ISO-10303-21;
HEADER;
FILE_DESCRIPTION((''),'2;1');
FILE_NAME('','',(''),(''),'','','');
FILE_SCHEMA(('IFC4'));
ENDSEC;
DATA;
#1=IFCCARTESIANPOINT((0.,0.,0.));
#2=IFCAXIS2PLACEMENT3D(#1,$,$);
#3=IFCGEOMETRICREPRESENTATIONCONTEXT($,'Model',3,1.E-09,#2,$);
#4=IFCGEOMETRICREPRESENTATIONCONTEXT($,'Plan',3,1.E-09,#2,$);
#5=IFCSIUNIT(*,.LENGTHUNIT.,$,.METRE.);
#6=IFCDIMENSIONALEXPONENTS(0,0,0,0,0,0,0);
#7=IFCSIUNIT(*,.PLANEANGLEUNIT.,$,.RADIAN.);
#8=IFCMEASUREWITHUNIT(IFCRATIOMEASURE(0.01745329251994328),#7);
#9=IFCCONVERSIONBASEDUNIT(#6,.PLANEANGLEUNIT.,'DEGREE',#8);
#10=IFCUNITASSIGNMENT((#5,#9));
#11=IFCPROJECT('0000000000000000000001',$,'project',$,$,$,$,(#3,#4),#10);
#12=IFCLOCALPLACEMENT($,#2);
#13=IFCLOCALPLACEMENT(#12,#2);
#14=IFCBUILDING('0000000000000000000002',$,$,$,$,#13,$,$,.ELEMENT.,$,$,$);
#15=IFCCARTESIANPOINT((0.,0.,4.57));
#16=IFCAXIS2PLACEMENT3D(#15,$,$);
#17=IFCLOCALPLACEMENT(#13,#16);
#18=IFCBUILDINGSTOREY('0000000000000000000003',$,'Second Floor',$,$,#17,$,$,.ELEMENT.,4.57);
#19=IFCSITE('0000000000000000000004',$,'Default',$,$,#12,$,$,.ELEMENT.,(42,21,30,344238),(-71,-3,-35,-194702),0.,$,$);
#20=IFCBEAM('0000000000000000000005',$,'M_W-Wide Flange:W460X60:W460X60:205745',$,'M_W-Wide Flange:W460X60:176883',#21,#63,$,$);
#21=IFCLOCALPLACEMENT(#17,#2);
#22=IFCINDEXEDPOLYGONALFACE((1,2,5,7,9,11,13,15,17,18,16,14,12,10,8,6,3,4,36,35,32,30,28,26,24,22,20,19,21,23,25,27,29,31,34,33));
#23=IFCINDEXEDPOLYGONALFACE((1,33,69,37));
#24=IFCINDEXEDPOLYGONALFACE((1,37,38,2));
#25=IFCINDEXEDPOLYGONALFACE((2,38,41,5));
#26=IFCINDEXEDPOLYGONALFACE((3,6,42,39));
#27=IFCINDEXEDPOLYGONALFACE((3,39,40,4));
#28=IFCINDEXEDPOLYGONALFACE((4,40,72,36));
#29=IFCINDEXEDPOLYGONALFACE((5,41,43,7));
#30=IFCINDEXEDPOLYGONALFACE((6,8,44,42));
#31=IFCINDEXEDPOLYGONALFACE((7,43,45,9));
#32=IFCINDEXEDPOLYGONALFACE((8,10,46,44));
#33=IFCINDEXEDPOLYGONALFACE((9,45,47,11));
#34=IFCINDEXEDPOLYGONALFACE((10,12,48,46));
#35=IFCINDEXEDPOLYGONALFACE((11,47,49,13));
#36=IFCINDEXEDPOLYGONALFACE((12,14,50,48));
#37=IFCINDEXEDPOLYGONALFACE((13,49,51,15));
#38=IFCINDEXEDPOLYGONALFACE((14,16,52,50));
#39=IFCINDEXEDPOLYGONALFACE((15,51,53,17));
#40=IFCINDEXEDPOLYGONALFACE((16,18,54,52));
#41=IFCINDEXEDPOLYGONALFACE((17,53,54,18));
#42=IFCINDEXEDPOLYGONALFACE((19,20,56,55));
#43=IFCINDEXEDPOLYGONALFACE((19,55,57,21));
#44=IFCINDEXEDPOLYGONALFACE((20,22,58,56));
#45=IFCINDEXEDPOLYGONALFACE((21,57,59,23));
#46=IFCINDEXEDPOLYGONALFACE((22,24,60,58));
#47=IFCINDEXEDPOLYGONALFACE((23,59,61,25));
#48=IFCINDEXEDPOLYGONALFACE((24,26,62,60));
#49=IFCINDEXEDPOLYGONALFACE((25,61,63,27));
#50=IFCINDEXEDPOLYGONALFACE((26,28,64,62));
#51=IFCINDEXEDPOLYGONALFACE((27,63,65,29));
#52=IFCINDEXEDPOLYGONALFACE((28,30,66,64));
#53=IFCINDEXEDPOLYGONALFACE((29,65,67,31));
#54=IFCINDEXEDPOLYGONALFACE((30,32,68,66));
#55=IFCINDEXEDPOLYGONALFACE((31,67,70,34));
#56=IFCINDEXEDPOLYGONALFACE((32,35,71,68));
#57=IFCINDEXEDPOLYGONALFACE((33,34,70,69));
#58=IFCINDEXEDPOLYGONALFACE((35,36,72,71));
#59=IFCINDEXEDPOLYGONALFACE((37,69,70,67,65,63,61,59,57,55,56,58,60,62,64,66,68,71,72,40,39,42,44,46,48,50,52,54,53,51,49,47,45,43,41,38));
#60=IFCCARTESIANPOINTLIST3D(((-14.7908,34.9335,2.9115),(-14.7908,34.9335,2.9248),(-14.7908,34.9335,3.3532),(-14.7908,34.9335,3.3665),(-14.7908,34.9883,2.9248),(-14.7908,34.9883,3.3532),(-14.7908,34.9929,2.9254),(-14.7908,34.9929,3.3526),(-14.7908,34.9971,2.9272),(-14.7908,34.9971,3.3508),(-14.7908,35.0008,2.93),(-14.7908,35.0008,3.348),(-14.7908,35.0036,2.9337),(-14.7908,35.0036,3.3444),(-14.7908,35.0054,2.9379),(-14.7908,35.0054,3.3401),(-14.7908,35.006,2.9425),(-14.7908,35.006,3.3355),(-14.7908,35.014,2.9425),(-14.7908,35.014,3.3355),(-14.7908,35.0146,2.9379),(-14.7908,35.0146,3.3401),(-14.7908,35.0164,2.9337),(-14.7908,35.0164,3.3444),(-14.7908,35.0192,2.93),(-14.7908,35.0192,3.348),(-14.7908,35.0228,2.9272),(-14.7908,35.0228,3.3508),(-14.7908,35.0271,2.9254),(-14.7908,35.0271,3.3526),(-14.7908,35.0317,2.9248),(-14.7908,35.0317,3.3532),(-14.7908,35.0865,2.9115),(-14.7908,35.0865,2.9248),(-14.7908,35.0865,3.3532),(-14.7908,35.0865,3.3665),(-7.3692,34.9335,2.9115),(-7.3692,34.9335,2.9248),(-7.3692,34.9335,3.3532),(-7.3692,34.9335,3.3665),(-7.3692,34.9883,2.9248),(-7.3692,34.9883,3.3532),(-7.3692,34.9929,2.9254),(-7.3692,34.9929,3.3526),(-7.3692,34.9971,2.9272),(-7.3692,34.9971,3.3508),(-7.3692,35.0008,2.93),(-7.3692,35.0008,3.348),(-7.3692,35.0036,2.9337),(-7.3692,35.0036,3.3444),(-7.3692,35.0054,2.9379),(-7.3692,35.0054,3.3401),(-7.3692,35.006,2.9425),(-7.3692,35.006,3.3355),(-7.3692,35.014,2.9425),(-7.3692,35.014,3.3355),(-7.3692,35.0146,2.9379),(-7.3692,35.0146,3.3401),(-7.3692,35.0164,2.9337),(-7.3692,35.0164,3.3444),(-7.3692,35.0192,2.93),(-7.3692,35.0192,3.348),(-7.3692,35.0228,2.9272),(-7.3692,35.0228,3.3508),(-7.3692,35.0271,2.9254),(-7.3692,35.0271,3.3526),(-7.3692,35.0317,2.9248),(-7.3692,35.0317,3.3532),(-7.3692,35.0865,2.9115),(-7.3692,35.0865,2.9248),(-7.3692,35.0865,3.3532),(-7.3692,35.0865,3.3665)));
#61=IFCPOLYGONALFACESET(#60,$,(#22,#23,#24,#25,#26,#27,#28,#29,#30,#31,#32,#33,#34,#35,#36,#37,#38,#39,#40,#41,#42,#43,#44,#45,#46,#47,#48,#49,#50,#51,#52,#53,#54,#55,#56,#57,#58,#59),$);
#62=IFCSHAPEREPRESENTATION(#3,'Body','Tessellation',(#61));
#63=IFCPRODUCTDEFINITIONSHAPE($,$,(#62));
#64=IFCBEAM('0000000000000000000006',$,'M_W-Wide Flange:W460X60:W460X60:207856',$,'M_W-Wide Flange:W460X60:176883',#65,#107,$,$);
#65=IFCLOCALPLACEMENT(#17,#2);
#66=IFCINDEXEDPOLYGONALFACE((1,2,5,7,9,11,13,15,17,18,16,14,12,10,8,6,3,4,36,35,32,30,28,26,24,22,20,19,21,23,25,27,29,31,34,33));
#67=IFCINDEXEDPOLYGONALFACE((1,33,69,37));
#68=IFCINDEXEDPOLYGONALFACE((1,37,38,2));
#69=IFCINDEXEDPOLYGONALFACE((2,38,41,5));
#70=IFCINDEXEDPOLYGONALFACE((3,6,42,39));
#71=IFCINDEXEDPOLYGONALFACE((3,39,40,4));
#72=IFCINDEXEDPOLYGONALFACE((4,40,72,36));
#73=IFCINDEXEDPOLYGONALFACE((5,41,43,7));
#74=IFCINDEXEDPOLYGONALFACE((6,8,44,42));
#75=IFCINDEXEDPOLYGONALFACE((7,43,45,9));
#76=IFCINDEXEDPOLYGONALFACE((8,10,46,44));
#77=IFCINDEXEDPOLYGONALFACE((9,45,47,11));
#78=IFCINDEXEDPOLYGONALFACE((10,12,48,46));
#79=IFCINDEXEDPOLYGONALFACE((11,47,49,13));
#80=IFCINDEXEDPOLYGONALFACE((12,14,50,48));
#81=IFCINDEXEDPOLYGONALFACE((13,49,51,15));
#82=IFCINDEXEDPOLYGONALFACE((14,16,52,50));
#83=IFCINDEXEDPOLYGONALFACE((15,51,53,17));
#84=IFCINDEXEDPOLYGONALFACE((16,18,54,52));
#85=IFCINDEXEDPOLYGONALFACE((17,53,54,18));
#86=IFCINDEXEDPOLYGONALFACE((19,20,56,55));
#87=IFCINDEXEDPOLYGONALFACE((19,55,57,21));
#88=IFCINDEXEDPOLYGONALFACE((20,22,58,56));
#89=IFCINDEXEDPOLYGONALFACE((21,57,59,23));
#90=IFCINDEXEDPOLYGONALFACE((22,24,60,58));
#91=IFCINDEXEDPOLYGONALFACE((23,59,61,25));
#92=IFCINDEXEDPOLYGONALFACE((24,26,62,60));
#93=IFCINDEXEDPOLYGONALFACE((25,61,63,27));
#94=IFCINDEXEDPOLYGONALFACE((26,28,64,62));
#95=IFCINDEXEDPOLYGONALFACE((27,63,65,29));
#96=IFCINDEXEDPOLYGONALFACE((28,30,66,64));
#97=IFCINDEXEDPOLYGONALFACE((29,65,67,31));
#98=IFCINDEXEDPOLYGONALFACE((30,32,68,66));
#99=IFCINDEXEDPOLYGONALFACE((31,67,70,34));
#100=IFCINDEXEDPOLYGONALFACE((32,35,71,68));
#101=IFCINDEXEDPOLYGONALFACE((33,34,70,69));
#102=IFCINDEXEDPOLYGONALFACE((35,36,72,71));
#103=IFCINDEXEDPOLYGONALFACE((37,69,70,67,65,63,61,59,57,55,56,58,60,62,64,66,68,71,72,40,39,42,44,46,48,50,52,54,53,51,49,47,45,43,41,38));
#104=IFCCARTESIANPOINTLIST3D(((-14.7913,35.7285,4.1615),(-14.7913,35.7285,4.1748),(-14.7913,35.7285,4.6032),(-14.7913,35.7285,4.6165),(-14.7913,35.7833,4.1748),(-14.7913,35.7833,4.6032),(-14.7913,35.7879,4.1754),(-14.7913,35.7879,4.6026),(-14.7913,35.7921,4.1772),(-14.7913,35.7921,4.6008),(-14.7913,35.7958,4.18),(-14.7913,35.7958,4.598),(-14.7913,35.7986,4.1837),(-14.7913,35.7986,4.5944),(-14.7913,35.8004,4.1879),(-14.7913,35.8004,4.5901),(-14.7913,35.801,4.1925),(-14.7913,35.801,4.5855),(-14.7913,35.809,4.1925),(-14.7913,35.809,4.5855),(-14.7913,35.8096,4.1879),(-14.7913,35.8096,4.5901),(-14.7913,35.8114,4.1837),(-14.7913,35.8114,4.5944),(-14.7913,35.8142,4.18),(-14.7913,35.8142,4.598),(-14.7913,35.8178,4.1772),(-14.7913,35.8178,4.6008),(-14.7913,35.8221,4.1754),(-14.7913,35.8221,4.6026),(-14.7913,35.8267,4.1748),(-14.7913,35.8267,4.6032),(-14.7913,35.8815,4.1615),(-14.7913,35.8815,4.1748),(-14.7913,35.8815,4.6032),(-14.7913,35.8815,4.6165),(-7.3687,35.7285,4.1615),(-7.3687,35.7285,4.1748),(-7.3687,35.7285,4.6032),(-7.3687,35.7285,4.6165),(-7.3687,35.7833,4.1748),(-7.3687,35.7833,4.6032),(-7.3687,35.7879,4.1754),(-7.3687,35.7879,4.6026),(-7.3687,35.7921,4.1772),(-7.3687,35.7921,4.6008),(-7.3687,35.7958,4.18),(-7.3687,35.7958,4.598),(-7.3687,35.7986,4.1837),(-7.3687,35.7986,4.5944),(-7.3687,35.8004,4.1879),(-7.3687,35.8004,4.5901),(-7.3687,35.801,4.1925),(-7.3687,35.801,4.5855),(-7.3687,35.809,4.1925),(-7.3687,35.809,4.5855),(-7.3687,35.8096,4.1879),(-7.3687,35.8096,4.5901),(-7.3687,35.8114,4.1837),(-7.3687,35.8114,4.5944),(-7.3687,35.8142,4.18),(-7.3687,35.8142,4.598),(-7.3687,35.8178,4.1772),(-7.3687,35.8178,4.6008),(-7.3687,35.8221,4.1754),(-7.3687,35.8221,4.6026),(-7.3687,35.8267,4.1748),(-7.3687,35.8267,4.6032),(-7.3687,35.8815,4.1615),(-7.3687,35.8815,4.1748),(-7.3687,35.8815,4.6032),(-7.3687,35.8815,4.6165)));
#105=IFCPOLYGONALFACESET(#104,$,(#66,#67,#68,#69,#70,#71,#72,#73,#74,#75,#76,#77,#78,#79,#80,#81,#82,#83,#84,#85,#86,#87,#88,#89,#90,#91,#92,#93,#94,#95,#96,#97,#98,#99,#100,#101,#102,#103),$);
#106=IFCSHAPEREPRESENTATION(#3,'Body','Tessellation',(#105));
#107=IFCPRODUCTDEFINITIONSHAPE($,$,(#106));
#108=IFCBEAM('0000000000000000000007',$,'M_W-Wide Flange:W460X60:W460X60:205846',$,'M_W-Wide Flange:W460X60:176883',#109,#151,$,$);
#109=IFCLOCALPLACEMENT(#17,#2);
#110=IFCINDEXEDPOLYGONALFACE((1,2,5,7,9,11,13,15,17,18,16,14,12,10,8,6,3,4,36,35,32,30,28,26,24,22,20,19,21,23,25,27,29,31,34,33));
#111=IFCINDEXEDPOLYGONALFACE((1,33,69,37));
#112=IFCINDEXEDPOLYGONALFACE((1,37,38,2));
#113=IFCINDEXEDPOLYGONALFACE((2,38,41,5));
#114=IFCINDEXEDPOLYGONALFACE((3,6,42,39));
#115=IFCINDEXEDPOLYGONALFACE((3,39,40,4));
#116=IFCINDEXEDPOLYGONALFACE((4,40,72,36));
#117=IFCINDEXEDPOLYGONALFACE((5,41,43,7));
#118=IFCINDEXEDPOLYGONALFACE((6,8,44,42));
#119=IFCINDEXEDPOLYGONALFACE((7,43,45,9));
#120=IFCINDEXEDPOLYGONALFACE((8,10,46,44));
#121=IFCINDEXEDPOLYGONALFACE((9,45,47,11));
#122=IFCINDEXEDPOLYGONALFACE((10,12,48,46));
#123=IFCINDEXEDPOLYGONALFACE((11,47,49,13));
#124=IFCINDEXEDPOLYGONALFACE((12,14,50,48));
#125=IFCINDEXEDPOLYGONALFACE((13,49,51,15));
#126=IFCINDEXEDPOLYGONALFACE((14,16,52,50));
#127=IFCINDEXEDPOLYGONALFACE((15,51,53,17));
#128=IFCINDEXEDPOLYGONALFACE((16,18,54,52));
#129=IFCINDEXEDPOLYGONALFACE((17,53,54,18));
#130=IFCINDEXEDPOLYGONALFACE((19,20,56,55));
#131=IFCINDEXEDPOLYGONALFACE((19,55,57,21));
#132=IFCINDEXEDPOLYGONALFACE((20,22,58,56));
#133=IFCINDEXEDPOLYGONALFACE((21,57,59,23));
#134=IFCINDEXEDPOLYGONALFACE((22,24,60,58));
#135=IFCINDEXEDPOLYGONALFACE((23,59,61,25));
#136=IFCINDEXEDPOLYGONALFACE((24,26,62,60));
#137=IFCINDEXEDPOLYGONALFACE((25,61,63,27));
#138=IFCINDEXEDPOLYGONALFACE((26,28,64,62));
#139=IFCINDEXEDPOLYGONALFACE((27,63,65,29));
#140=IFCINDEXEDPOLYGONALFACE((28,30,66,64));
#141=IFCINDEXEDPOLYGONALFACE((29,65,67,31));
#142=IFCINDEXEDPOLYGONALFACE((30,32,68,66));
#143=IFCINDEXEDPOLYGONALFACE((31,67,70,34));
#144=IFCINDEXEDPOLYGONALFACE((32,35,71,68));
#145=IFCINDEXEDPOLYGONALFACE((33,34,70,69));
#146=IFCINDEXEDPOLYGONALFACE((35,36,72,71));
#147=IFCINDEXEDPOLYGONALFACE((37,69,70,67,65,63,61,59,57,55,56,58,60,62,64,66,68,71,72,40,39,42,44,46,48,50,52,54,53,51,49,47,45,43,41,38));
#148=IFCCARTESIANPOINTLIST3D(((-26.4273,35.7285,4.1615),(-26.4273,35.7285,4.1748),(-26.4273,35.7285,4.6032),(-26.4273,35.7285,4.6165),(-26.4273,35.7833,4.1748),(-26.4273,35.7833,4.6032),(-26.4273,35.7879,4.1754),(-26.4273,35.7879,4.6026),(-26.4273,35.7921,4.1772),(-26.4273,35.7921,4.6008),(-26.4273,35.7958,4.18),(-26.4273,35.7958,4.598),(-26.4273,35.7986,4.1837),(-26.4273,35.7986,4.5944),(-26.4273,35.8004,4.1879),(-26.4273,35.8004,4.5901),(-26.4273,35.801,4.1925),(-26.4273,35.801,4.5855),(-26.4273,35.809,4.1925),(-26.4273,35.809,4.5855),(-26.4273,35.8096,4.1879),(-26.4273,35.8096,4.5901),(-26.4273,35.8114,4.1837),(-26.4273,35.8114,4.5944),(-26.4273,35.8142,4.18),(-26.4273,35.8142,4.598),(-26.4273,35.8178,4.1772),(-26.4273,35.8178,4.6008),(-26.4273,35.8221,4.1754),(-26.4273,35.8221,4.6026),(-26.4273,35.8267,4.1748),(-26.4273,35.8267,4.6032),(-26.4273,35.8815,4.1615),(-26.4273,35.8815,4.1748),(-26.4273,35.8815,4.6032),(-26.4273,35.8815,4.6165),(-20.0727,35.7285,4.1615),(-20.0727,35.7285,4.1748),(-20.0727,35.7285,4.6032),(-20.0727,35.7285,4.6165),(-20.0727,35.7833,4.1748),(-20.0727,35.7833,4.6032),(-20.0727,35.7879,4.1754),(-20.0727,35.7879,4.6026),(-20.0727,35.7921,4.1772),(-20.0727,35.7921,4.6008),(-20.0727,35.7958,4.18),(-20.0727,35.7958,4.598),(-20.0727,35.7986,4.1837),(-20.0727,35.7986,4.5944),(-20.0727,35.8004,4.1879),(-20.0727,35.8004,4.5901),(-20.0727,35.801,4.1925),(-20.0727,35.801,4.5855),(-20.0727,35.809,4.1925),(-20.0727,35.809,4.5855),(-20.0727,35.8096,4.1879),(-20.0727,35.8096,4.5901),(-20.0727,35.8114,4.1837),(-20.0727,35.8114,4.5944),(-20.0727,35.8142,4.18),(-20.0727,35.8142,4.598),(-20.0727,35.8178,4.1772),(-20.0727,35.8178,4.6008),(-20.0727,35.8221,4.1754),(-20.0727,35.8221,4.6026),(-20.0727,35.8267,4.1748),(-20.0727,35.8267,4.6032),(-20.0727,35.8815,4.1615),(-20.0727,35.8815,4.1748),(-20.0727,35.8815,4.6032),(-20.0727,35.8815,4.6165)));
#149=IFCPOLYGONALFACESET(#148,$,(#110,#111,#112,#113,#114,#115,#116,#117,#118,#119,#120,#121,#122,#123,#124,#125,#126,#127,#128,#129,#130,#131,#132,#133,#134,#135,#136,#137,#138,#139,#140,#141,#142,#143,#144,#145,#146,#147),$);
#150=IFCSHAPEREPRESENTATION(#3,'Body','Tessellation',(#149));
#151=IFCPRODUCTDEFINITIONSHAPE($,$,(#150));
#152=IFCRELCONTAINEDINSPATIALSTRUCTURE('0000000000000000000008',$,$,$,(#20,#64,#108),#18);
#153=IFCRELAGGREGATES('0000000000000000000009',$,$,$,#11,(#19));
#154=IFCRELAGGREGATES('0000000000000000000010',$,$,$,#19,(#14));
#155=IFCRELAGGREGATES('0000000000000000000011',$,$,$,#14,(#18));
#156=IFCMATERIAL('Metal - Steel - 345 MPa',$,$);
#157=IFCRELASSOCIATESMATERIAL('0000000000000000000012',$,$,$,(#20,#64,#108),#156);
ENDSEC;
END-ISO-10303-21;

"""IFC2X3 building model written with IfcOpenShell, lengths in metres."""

from ifc_helpers import new_model, entity, si_unit, converted_unit, frame, frame_2d, origin, place, context, project, spatial, polyline, circle_curve, parameter, trimmed, segment, composite_curve, outline, extrude, material, element, save


model = new_model("IFC2X3")

# Units and contexts
model_context = context("Model", 3, precision=1e-09, world=origin())
plan_context = context("Plan", 3, precision=1e-09, world=origin())
ifc_project = project(units=[si_unit("LENGTHUNIT", "METRE"), converted_unit("PLANEANGLEUNIT", "DEGREE", entity("IfcRatioMeasure", 0.01745329251994328), si_unit("PLANEANGLEUNIT", "RADIAN"), dimensions=[0, 0, 0, 0, 0, 0, 0])], contexts=[model_context, plan_context])

# Site, building, storey
site_placement = place(None, origin())
site = spatial("IfcSite", under=ifc_project, at=site_placement, Name="Default", CompositionType="ELEMENT", RefLatitude=(42, 21, 30, 344238), RefLongitude=(-71, -3, -35, -194702), RefElevation=0.0)
building_placement = place(site_placement, origin())
building = spatial("IfcBuilding", under=site, at=building_placement, CompositionType="ELEMENT")
storey_placement = place(building_placement, frame((0.0, 0.0, 4.57)))
storey = spatial("IfcBuildingStorey", under=building, at=storey_placement, Name="Second Floor", CompositionType="ELEMENT", Elevation=4.57)

# Shared definitions
ifc_material = material(Name="Metal - Steel - 345 MPa")

# Beams
beam_1_placement = place(storey_placement, frame((-7.2774, 35.01, 3.3665), z_axis=(0.0, 0.0, 1.0), x_axis=(0.0, -1.0, 0.0)))
element("IfcBeam", 1, at=beam_1_placement, inside=storey, material=ifc_material, Name="M_W-Wide Flange:W460X60:W460X60:205745", ObjectType="M_W-Wide Flange:W460X60:176883", context=model_context, shape_type="SweptSolid", body=[
    extrude(outline(composite_curve([segment(polyline([(-0.0765, -0.2142), (-0.0765, -0.2275)]), True, "CONTINUOUS"), segment(polyline([(-0.0765, -0.2275), (0.0765, -0.2275)]), True, "CONTINUOUS"), segment(polyline([(0.0765, -0.2275), (0.0765, -0.2142)]), True, "CONTINUOUS"), segment(polyline([(0.0765, -0.2142), (0.0217, -0.2142)]), True, "CONTINUOUS"), segment(trimmed(circle_curve(frame_2d((0.0217, -0.1965), x_axis=(1.0, 0.0)), 0.0177), [parameter(180.0)], [parameter(270.0)], True, "PARAMETER"), False, "CONTINUOUS"), segment(polyline([(0.004, -0.1965), (0.004, 0.1965)]), True, "CONTINUOUS"), segment(trimmed(circle_curve(frame_2d((0.0217, 0.1965), x_axis=(1.0, 0.0)), 0.0177), [parameter(90.0)], [parameter(180.0)], True, "PARAMETER"), False, "CONTINUOUS"), segment(polyline([(0.0217, 0.2142), (0.0765, 0.2142)]), True, "CONTINUOUS"), segment(polyline([(0.0765, 0.2142), (0.0765, 0.2275)]), True, "CONTINUOUS"), segment(polyline([(0.0765, 0.2275), (-0.0765, 0.2275)]), True, "CONTINUOUS"), segment(polyline([(-0.0765, 0.2275), (-0.0765, 0.2142)]), True, "CONTINUOUS"), segment(polyline([(-0.0765, 0.2142), (-0.0217, 0.2142)]), True, "CONTINUOUS"), segment(trimmed(circle_curve(frame_2d((-0.0217, 0.1965), x_axis=(1.0, 0.0)), 0.0177), [parameter(360.0)], [parameter(90.0)], True, "PARAMETER"), False, "CONTINUOUS"), segment(polyline([(-0.004, 0.1965), (-0.004, -0.1965)]), True, "CONTINUOUS"), segment(trimmed(circle_curve(frame_2d((-0.0217, -0.1965), x_axis=(1.0, 0.0)), 0.0177), [parameter(270.0)], [parameter(0.0)], True, "PARAMETER"), False, "CONTINUOUS"), segment(polyline([(-0.0217, -0.2142), (-0.0765, -0.2142)]), True, "CONTINUOUS")], self_intersect=False)), frame((0.0, -7.5134, -0.2275), z_axis=(0.0, -1.0, 0.0), x_axis=(1.0, 0.0, 0.0)), (0.0, 0.0, -1.0), 7.4216),
])
beam_2_placement = place(storey_placement, frame((-7.2773, 35.805, 4.6165), z_axis=(0.0, 0.0, 1.0), x_axis=(0.0, -1.0, 0.0)))
element("IfcBeam", 2, at=beam_2_placement, inside=storey, material=ifc_material, Name="M_W-Wide Flange:W460X60:W460X60:207856", ObjectType="M_W-Wide Flange:W460X60:176883", context=model_context, shape_type="SweptSolid", body=[
    extrude(outline(composite_curve([segment(polyline([(-0.0765, -0.2142), (-0.0765, -0.2275)]), True, "CONTINUOUS"), segment(polyline([(-0.0765, -0.2275), (0.0765, -0.2275)]), True, "CONTINUOUS"), segment(polyline([(0.0765, -0.2275), (0.0765, -0.2142)]), True, "CONTINUOUS"), segment(polyline([(0.0765, -0.2142), (0.0217, -0.2142)]), True, "CONTINUOUS"), segment(trimmed(circle_curve(frame_2d((0.0217, -0.1965), x_axis=(1.0, 0.0)), 0.0177), [parameter(180.0)], [parameter(270.0)], True, "PARAMETER"), False, "CONTINUOUS"), segment(polyline([(0.004, -0.1965), (0.004, 0.1965)]), True, "CONTINUOUS"), segment(trimmed(circle_curve(frame_2d((0.0217, 0.1965), x_axis=(1.0, 0.0)), 0.0177), [parameter(90.0)], [parameter(180.0)], True, "PARAMETER"), False, "CONTINUOUS"), segment(polyline([(0.0217, 0.2142), (0.0765, 0.2142)]), True, "CONTINUOUS"), segment(polyline([(0.0765, 0.2142), (0.0765, 0.2275)]), True, "CONTINUOUS"), segment(polyline([(0.0765, 0.2275), (-0.0765, 0.2275)]), True, "CONTINUOUS"), segment(polyline([(-0.0765, 0.2275), (-0.0765, 0.2142)]), True, "CONTINUOUS"), segment(polyline([(-0.0765, 0.2142), (-0.0217, 0.2142)]), True, "CONTINUOUS"), segment(trimmed(circle_curve(frame_2d((-0.0217, 0.1965), x_axis=(1.0, 0.0)), 0.0177), [parameter(360.0)], [parameter(90.0)], True, "PARAMETER"), False, "CONTINUOUS"), segment(polyline([(-0.004, 0.1965), (-0.004, -0.1965)]), True, "CONTINUOUS"), segment(trimmed(circle_curve(frame_2d((-0.0217, -0.1965), x_axis=(1.0, 0.0)), 0.0177), [parameter(270.0)], [parameter(0.0)], True, "PARAMETER"), False, "CONTINUOUS"), segment(polyline([(-0.0217, -0.2142), (-0.0765, -0.2142)]), True, "CONTINUOUS")], self_intersect=False)), frame((0.0, -7.5139, -0.2275), z_axis=(0.0, -1.0, 0.0), x_axis=(1.0, 0.0, 0.0)), (0.0, 0.0, -1.0), 7.4226),
])
beam_3_placement = place(storey_placement, frame((-7.2786, 35.805, 4.6165), z_axis=(0.0, 0.0, 1.0), x_axis=(0.0, -1.0, 0.0)))
element("IfcBeam", 3, at=beam_3_placement, inside=storey, material=ifc_material, Name="M_W-Wide Flange:W460X60:W460X60:205846", ObjectType="M_W-Wide Flange:W460X60:176883", context=model_context, shape_type="SweptSolid", body=[
    extrude(outline(composite_curve([segment(polyline([(-0.0765, -0.2142), (-0.0765, -0.2275)]), True, "CONTINUOUS"), segment(polyline([(-0.0765, -0.2275), (0.0765, -0.2275)]), True, "CONTINUOUS"), segment(polyline([(0.0765, -0.2275), (0.0765, -0.2142)]), True, "CONTINUOUS"), segment(polyline([(0.0765, -0.2142), (0.0217, -0.2142)]), True, "CONTINUOUS"), segment(trimmed(circle_curve(frame_2d((0.0217, -0.1965), x_axis=(1.0, 0.0)), 0.0177), [parameter(180.0)], [parameter(270.0)], True, "PARAMETER"), False, "CONTINUOUS"), segment(polyline([(0.004, -0.1965), (0.004, 0.1965)]), True, "CONTINUOUS"), segment(trimmed(circle_curve(frame_2d((0.0217, 0.1965), x_axis=(1.0, 0.0)), 0.0177), [parameter(90.0)], [parameter(180.0)], True, "PARAMETER"), False, "CONTINUOUS"), segment(polyline([(0.0217, 0.2142), (0.0765, 0.2142)]), True, "CONTINUOUS"), segment(polyline([(0.0765, 0.2142), (0.0765, 0.2275)]), True, "CONTINUOUS"), segment(polyline([(0.0765, 0.2275), (-0.0765, 0.2275)]), True, "CONTINUOUS"), segment(polyline([(-0.0765, 0.2275), (-0.0765, 0.2142)]), True, "CONTINUOUS"), segment(polyline([(-0.0765, 0.2142), (-0.0217, 0.2142)]), True, "CONTINUOUS"), segment(trimmed(circle_curve(frame_2d((-0.0217, 0.1965), x_axis=(1.0, 0.0)), 0.0177), [parameter(360.0)], [parameter(90.0)], True, "PARAMETER"), False, "CONTINUOUS"), segment(polyline([(-0.004, 0.1965), (-0.004, -0.1965)]), True, "CONTINUOUS"), segment(trimmed(circle_curve(frame_2d((-0.0217, -0.1965), x_axis=(1.0, 0.0)), 0.0177), [parameter(270.0)], [parameter(0.0)], True, "PARAMETER"), False, "CONTINUOUS"), segment(polyline([(-0.0217, -0.2142), (-0.0765, -0.2142)]), True, "CONTINUOUS")], self_intersect=False)), frame((0.0, -19.1487, -0.2275), z_axis=(0.0, -1.0, 0.0), x_axis=(1.0, 0.0, 0.0)), (0.0, 0.0, -1.0), 6.3546),
])

save(model, "model.ifc")
